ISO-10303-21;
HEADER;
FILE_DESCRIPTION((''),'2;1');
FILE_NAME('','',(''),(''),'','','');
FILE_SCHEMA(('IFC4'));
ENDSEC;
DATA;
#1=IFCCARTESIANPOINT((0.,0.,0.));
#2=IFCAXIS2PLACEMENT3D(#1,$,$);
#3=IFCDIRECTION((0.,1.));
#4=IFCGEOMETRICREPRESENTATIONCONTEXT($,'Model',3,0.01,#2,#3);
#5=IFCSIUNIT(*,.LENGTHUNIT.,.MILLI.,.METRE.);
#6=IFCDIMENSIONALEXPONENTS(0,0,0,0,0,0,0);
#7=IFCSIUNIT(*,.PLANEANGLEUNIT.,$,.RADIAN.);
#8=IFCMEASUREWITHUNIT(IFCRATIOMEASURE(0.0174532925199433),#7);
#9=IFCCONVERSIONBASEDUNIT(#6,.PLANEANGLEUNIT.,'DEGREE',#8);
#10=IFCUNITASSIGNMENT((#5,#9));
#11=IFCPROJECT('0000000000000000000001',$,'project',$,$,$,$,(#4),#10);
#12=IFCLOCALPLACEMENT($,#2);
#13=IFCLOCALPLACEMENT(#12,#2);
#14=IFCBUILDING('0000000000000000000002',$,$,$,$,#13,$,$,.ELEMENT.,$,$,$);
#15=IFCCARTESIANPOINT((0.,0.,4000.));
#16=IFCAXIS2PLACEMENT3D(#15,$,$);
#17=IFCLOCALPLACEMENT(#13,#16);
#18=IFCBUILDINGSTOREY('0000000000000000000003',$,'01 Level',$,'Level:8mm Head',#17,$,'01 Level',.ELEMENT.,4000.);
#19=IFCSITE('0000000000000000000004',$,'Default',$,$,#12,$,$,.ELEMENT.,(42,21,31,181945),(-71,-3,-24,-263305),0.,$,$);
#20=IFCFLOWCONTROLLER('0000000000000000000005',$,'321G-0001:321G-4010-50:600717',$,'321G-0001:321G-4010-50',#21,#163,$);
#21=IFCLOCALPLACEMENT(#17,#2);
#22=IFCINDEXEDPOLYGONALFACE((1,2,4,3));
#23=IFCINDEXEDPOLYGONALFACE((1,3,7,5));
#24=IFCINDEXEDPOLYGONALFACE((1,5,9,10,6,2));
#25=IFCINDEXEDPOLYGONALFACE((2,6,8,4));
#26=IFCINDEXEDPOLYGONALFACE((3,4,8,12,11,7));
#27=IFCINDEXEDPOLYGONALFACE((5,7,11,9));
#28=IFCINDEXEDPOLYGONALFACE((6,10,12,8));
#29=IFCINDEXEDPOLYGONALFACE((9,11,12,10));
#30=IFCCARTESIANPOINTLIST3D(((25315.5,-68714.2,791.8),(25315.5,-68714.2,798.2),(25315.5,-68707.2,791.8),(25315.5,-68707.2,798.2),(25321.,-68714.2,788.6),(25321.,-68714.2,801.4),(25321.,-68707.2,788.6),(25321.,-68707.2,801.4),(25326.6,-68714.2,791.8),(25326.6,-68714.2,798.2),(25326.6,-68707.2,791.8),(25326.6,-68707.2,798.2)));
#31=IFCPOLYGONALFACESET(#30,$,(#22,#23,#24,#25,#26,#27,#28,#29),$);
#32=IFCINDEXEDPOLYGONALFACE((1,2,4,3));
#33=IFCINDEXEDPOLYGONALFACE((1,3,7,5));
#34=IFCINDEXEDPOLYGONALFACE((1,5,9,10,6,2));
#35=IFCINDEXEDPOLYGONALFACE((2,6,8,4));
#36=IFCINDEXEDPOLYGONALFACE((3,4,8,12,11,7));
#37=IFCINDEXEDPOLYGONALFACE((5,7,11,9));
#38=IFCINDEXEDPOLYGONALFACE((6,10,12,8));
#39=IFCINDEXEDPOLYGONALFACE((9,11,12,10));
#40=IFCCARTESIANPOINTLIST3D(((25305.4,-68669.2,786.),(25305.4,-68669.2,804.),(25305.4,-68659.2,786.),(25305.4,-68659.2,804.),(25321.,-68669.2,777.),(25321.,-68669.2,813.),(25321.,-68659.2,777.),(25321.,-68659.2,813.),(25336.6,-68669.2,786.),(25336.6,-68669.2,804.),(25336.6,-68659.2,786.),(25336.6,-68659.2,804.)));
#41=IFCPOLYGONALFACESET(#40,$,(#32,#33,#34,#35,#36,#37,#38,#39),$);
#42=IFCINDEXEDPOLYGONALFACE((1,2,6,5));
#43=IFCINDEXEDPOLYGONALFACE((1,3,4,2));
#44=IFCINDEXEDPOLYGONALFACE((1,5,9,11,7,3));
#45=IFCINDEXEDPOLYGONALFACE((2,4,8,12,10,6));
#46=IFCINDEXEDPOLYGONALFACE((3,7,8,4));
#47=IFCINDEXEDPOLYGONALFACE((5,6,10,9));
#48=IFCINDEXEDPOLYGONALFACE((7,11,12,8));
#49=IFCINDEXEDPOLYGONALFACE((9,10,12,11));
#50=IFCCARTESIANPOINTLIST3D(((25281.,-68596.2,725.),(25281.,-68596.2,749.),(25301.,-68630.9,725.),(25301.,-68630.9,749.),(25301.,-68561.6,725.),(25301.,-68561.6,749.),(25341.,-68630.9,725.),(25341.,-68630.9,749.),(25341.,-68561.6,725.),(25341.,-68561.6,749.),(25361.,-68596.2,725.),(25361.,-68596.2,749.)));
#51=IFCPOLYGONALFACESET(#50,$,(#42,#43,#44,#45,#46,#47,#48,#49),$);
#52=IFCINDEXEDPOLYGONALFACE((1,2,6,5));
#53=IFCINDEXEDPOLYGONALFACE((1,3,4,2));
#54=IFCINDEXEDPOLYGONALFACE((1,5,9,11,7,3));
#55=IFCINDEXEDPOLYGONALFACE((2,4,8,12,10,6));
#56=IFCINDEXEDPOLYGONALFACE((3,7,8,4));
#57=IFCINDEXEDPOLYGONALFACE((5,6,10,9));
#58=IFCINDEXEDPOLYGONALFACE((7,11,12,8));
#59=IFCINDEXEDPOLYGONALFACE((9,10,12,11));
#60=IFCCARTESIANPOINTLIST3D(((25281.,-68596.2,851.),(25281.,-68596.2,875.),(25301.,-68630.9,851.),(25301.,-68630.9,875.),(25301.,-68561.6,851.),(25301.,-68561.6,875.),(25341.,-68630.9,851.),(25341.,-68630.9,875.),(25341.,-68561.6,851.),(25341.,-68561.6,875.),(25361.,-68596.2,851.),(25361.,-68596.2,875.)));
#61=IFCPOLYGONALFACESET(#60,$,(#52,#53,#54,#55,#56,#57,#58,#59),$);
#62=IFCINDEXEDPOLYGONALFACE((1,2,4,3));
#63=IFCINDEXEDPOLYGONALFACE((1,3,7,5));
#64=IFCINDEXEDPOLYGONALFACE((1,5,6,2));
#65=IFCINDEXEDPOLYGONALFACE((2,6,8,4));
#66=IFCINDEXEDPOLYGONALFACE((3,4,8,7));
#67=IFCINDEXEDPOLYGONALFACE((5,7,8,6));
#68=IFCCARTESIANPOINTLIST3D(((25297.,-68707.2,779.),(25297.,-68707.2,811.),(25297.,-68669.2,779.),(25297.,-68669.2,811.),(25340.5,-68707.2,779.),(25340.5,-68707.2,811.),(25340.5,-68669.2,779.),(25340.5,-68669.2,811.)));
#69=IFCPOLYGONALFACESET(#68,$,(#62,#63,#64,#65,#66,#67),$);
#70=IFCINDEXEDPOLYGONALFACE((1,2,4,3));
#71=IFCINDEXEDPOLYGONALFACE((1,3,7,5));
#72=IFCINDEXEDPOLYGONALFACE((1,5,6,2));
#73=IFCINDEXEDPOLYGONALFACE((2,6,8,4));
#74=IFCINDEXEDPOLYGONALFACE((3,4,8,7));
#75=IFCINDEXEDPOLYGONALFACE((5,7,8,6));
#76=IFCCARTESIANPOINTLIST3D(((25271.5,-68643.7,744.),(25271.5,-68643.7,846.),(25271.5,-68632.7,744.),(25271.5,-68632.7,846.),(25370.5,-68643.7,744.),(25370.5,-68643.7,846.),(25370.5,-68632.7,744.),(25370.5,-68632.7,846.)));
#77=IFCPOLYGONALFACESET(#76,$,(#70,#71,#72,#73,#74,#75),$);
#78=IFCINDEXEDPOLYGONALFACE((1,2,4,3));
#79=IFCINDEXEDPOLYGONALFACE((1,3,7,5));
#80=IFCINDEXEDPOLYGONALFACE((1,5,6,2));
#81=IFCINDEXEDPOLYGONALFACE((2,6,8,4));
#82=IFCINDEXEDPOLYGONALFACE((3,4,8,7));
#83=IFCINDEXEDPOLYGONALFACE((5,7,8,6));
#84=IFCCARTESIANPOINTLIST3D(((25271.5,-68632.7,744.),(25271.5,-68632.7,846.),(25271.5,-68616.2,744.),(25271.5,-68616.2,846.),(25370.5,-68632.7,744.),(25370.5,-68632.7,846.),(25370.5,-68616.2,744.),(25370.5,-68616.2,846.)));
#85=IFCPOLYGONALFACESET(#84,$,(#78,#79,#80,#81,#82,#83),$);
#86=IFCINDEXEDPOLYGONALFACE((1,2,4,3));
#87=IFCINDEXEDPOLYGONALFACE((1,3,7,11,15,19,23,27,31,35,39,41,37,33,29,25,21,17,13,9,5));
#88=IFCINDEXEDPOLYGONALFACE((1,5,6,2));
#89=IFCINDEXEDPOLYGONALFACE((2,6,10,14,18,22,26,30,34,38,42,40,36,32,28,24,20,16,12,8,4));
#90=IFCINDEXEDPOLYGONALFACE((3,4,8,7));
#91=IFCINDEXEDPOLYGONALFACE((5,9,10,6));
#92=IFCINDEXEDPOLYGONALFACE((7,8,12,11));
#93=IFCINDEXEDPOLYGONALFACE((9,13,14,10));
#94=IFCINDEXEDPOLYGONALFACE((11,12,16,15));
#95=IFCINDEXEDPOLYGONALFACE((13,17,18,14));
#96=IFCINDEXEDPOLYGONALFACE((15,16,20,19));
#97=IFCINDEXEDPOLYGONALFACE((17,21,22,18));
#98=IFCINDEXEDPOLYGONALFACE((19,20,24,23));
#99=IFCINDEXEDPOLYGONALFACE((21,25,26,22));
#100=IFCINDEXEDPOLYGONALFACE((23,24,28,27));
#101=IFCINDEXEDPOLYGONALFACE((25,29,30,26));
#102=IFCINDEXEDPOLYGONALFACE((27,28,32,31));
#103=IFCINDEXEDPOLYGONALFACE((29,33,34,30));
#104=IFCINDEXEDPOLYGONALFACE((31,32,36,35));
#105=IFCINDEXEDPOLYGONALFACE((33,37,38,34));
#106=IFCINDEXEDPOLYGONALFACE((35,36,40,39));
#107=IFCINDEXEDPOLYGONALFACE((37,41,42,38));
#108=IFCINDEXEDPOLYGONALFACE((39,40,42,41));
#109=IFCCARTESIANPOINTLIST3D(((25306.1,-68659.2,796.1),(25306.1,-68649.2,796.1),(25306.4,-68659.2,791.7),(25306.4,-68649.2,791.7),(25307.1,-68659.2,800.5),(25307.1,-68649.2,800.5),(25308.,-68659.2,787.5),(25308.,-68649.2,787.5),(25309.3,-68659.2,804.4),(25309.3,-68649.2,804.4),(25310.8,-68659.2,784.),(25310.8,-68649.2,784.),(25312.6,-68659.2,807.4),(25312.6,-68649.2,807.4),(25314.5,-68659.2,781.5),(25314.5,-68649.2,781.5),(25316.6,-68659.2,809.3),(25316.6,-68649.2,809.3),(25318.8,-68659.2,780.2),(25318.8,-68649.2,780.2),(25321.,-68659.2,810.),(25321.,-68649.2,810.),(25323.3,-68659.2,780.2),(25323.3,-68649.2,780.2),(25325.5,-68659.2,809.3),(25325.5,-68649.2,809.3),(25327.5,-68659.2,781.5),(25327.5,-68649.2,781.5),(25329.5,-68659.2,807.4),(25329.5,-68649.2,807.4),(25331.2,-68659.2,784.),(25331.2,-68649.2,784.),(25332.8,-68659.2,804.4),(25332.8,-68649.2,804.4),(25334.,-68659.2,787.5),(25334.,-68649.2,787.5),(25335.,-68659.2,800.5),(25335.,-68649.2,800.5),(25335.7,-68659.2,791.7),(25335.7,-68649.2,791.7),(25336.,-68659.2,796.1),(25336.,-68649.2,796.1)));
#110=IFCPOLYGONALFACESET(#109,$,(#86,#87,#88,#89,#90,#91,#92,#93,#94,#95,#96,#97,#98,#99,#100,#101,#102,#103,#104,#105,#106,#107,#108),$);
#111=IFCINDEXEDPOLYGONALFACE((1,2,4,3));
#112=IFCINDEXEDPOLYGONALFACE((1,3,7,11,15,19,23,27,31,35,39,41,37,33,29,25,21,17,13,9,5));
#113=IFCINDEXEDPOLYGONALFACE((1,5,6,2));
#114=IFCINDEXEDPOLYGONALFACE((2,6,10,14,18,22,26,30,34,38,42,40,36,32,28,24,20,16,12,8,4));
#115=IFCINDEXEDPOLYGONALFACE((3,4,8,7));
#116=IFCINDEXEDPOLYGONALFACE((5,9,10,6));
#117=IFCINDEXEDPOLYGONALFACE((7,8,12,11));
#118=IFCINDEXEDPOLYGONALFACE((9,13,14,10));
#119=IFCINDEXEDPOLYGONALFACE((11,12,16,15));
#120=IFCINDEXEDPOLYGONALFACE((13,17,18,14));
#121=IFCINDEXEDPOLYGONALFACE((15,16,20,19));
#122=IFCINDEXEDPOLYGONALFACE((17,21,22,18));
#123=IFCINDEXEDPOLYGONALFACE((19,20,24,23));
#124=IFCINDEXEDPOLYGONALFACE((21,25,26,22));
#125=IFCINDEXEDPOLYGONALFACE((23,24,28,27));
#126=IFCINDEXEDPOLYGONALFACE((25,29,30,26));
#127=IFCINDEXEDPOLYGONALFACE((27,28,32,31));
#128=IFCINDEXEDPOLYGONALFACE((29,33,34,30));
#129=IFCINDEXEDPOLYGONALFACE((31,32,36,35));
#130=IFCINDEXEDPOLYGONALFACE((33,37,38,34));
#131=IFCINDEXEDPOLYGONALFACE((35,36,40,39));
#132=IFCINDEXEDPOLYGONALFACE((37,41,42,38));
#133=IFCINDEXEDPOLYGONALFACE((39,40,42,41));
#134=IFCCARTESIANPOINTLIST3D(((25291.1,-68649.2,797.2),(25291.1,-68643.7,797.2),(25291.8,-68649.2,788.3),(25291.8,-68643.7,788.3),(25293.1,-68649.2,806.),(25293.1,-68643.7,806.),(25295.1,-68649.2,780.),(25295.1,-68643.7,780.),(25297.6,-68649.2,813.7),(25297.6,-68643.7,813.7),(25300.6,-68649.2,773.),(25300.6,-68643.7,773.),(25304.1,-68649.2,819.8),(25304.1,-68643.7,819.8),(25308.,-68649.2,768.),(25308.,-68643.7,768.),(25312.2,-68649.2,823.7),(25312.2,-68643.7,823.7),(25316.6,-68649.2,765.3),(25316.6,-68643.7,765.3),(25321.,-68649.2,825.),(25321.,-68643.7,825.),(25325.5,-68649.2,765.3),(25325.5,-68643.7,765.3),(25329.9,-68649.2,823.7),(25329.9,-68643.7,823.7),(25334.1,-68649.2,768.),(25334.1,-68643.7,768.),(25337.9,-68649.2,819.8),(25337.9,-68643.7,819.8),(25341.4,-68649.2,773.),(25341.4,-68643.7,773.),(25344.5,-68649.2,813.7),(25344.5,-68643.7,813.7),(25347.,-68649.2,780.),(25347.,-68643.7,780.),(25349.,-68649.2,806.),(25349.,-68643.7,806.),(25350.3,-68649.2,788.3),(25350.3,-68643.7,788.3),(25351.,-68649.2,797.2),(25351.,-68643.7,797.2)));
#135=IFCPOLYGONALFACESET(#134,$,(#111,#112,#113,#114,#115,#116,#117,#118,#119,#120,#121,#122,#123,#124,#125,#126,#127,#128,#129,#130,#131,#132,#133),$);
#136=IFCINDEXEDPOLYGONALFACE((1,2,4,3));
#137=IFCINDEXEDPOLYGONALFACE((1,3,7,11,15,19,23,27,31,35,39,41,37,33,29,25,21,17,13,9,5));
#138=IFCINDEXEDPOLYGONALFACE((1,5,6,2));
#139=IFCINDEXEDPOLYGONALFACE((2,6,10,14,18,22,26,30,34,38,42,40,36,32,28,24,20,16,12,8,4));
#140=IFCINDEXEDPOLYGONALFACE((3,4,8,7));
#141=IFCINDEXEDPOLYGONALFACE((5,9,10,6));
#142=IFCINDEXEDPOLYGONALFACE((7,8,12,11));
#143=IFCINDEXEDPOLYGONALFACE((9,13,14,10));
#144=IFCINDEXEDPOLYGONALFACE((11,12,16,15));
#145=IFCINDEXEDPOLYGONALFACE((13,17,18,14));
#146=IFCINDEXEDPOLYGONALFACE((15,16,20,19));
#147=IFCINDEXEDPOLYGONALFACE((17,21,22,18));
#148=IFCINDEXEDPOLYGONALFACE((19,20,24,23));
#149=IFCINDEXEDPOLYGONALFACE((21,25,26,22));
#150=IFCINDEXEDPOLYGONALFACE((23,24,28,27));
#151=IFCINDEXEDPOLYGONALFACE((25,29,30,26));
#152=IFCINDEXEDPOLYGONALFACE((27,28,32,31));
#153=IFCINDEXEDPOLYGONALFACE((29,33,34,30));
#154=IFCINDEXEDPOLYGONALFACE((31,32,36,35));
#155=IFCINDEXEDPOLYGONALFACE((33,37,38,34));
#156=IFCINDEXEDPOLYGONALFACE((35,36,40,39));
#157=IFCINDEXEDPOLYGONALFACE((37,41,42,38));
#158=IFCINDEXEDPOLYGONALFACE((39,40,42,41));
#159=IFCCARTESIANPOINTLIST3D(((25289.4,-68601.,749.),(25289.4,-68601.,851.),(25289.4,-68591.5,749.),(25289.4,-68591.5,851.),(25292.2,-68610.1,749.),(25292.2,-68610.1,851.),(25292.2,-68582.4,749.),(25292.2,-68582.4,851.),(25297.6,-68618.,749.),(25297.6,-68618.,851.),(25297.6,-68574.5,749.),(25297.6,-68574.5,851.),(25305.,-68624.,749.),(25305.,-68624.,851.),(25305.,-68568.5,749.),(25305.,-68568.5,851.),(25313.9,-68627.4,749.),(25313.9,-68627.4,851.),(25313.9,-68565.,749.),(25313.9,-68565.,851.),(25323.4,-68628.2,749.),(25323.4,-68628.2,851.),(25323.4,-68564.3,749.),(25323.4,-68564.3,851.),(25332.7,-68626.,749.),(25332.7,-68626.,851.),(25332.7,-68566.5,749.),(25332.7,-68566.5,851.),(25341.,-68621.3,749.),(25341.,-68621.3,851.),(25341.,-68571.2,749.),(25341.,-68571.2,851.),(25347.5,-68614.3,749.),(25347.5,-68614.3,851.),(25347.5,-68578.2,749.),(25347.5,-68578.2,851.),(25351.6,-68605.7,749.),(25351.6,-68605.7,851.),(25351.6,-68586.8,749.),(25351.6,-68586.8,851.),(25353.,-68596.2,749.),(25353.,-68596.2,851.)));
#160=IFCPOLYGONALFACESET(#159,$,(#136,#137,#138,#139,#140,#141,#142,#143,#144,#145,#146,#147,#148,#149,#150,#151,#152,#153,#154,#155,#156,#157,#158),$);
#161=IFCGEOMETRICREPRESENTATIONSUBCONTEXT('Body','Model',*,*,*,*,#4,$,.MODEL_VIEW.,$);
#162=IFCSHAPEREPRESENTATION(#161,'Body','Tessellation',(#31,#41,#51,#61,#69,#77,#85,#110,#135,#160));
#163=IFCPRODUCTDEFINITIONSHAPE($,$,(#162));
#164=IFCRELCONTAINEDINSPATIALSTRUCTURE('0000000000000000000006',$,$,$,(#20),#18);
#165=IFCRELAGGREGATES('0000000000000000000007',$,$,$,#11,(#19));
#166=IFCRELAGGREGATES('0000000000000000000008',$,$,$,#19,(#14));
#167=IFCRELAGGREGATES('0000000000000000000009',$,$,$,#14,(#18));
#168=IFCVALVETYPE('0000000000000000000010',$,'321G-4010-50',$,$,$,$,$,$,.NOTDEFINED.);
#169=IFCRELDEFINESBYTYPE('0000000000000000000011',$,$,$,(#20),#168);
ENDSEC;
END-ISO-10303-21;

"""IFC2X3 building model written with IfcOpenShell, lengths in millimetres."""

from ifc_helpers import new_model, entity, si_unit, converted_unit, direction, frame, frame_2d, origin, origin_2d_with_axis, place, context, subcontext, project, spatial, polyline, rectangle, circle, outline, extrude, source, transform, mapped, type_object, type_shapes, element, save


model = new_model("IFC2X3")

# Units and contexts
model_context = context("Model", 3, precision=0.01, world=origin(), true_north=direction((0.0, 1.0)))
body_context = subcontext(model_context, "Body", "Model", "MODEL_VIEW")
ifc_project = project(units=[si_unit("LENGTHUNIT", "METRE", prefix="MILLI"), converted_unit("PLANEANGLEUNIT", "DEGREE", entity("IfcRatioMeasure", 0.0174532925199433), si_unit("PLANEANGLEUNIT", "RADIAN"), dimensions=[0, 0, 0, 0, 0, 0, 0])], contexts=[model_context])

# Site, building, storey
site_placement = place(None, origin())
site = spatial("IfcSite", under=ifc_project, at=site_placement, Name="Default", CompositionType="ELEMENT", RefLatitude=(42, 21, 31, 181945), RefLongitude=(-71, -3, -24, -263305), RefElevation=0.0)
building_placement = place(site_placement, origin())
building = spatial("IfcBuilding", under=site, at=building_placement, CompositionType="ELEMENT")
storey_placement = place(building_placement, frame((0.0, 0.0, 4000.0)))
storey = spatial("IfcBuildingStorey", under=building, at=storey_placement, Name="01 Level", ObjectType="Level:8mm Head", LongName="01 Level", CompositionType="ELEMENT", Elevation=4000.0)

# Flow controller
valve_type_1 = type_object("IfcValveType", Name="321G-4010-50", PredefinedType="NOTDEFINED")
shared_shape_1 = source(origin(), body_context, "Body", "SweptSolid", [
    extrude(outline(polyline([(-3.2, -5.5), (3.2, -5.5), (6.4, 0.0), (3.2, 5.5), (-3.2, 5.5), (-6.4, 0.0), (-3.2, -5.5)])), frame((-5.0, 0.0, 111.0), z_axis=(0.0, 0.0, 1.0), x_axis=(0.5, 0.866025, 0.0)), (0.0, 0.0, 1.0), 7.0),
    extrude(outline(polyline([(-9.0, -15.6), (9.0, -15.6), (18.0, 0.0), (9.0, 15.6), (-9.0, 15.6), (-18.0, 0.0), (-9.0, -15.6)])), frame((-5.0, 0.0, 63.0), z_axis=(0.0, 0.0, 1.0), x_axis=(0.5, 0.866025, 0.0)), (0.0, 0.0, 1.0), 10.0),
    extrude(outline(polyline([(-20.0, -34.6), (20.0, -34.6), (40.0, 0.0), (20.0, 34.6), (-20.0, 34.6), (-40.0, 0.0), (-20.0, -34.6)])), frame((-75.0, 0.0, 0.0), z_axis=(1.0, 0.0, 0.0), x_axis=(0.0, -0.5, -0.866025)), (0.0, 0.0, 1.0), 24.0),
    extrude(outline(polyline([(-20.0, -34.6), (20.0, -34.6), (40.0, 0.0), (20.0, 34.6), (-20.0, 34.6), (-40.0, 0.0), (-20.0, -34.6)])), frame((51.0, 0.0, 0.0), z_axis=(1.0, 0.0, 0.0), x_axis=(0.0, -0.5, -0.866025)), (0.0, 0.0, 1.0), 24.0),
    extrude(rectangle(XDim=43.5, YDim=32.0, at=frame_2d((0.0, 0.0), x_axis=(1.0, 0.0))), frame((-5.0, 2.2, 73.0), z_axis=(0.0, 0.0, 1.0), x_axis=(0.0, -1.0, 0.0)), (0.0, 0.0, 1.0), 38.0),
    extrude(rectangle(XDim=99.0, YDim=102.0, at=origin_2d_with_axis()), frame((-5.0, 0.0, 36.5), z_axis=(0.0, 0.0, 1.0), x_axis=(0.0, -1.0, 0.0)), (0.0, 0.0, 1.0), 11.0),
    extrude(rectangle(XDim=99.0, YDim=102.0, at=origin_2d_with_axis()), frame((-5.0, 0.0, 20.0), z_axis=(0.0, 0.0, 1.0), x_axis=(0.0, -1.0, 0.0)), (0.0, 0.0, 1.0), 16.5),
    extrude(circle(Radius=15.0, at=frame_2d((0.0, 0.0), x_axis=(1.0, 0.0))), frame((-5.0, 0.0, 53.0)), (0.0, 0.0, 1.0), 10.0),
    extrude(circle(Radius=30.0, at=frame_2d((0.0, 0.0), x_axis=(1.0, 0.0))), frame((-5.0, 0.0, 47.5)), (0.0, 0.0, 1.0), 5.5),
    extrude(circle(Radius=32.0, at=frame_2d((0.0, 0.0), x_axis=(1.0, 0.0))), frame((-51.0, 0.0, 0.0), z_axis=(1.0, 0.0, 0.0), x_axis=(0.0, -1.0, 0.0)), (0.0, 0.0, 1.0), 102.0),
])
type_shapes(valve_type_1, [shared_shape_1])
flow_controller_1_placement = place(storey_placement, frame((25321.0, -68596.2, 800.0), z_axis=(0.0, -1.0, 0.0), x_axis=(0.0, 0.0, 1.0)))
element("IfcFlowController", 1, at=flow_controller_1_placement, inside=storey, type_object=valve_type_1, Name="321G-0001:321G-4010-50:600717", ObjectType="321G-0001:321G-4010-50", context=body_context, shape_type="MappedRepresentation", body=[
    mapped(shared_shape_1, transform((0.0, 0.0, 0.0), scale=1.0)),
])

save(model, "model.ifc")
